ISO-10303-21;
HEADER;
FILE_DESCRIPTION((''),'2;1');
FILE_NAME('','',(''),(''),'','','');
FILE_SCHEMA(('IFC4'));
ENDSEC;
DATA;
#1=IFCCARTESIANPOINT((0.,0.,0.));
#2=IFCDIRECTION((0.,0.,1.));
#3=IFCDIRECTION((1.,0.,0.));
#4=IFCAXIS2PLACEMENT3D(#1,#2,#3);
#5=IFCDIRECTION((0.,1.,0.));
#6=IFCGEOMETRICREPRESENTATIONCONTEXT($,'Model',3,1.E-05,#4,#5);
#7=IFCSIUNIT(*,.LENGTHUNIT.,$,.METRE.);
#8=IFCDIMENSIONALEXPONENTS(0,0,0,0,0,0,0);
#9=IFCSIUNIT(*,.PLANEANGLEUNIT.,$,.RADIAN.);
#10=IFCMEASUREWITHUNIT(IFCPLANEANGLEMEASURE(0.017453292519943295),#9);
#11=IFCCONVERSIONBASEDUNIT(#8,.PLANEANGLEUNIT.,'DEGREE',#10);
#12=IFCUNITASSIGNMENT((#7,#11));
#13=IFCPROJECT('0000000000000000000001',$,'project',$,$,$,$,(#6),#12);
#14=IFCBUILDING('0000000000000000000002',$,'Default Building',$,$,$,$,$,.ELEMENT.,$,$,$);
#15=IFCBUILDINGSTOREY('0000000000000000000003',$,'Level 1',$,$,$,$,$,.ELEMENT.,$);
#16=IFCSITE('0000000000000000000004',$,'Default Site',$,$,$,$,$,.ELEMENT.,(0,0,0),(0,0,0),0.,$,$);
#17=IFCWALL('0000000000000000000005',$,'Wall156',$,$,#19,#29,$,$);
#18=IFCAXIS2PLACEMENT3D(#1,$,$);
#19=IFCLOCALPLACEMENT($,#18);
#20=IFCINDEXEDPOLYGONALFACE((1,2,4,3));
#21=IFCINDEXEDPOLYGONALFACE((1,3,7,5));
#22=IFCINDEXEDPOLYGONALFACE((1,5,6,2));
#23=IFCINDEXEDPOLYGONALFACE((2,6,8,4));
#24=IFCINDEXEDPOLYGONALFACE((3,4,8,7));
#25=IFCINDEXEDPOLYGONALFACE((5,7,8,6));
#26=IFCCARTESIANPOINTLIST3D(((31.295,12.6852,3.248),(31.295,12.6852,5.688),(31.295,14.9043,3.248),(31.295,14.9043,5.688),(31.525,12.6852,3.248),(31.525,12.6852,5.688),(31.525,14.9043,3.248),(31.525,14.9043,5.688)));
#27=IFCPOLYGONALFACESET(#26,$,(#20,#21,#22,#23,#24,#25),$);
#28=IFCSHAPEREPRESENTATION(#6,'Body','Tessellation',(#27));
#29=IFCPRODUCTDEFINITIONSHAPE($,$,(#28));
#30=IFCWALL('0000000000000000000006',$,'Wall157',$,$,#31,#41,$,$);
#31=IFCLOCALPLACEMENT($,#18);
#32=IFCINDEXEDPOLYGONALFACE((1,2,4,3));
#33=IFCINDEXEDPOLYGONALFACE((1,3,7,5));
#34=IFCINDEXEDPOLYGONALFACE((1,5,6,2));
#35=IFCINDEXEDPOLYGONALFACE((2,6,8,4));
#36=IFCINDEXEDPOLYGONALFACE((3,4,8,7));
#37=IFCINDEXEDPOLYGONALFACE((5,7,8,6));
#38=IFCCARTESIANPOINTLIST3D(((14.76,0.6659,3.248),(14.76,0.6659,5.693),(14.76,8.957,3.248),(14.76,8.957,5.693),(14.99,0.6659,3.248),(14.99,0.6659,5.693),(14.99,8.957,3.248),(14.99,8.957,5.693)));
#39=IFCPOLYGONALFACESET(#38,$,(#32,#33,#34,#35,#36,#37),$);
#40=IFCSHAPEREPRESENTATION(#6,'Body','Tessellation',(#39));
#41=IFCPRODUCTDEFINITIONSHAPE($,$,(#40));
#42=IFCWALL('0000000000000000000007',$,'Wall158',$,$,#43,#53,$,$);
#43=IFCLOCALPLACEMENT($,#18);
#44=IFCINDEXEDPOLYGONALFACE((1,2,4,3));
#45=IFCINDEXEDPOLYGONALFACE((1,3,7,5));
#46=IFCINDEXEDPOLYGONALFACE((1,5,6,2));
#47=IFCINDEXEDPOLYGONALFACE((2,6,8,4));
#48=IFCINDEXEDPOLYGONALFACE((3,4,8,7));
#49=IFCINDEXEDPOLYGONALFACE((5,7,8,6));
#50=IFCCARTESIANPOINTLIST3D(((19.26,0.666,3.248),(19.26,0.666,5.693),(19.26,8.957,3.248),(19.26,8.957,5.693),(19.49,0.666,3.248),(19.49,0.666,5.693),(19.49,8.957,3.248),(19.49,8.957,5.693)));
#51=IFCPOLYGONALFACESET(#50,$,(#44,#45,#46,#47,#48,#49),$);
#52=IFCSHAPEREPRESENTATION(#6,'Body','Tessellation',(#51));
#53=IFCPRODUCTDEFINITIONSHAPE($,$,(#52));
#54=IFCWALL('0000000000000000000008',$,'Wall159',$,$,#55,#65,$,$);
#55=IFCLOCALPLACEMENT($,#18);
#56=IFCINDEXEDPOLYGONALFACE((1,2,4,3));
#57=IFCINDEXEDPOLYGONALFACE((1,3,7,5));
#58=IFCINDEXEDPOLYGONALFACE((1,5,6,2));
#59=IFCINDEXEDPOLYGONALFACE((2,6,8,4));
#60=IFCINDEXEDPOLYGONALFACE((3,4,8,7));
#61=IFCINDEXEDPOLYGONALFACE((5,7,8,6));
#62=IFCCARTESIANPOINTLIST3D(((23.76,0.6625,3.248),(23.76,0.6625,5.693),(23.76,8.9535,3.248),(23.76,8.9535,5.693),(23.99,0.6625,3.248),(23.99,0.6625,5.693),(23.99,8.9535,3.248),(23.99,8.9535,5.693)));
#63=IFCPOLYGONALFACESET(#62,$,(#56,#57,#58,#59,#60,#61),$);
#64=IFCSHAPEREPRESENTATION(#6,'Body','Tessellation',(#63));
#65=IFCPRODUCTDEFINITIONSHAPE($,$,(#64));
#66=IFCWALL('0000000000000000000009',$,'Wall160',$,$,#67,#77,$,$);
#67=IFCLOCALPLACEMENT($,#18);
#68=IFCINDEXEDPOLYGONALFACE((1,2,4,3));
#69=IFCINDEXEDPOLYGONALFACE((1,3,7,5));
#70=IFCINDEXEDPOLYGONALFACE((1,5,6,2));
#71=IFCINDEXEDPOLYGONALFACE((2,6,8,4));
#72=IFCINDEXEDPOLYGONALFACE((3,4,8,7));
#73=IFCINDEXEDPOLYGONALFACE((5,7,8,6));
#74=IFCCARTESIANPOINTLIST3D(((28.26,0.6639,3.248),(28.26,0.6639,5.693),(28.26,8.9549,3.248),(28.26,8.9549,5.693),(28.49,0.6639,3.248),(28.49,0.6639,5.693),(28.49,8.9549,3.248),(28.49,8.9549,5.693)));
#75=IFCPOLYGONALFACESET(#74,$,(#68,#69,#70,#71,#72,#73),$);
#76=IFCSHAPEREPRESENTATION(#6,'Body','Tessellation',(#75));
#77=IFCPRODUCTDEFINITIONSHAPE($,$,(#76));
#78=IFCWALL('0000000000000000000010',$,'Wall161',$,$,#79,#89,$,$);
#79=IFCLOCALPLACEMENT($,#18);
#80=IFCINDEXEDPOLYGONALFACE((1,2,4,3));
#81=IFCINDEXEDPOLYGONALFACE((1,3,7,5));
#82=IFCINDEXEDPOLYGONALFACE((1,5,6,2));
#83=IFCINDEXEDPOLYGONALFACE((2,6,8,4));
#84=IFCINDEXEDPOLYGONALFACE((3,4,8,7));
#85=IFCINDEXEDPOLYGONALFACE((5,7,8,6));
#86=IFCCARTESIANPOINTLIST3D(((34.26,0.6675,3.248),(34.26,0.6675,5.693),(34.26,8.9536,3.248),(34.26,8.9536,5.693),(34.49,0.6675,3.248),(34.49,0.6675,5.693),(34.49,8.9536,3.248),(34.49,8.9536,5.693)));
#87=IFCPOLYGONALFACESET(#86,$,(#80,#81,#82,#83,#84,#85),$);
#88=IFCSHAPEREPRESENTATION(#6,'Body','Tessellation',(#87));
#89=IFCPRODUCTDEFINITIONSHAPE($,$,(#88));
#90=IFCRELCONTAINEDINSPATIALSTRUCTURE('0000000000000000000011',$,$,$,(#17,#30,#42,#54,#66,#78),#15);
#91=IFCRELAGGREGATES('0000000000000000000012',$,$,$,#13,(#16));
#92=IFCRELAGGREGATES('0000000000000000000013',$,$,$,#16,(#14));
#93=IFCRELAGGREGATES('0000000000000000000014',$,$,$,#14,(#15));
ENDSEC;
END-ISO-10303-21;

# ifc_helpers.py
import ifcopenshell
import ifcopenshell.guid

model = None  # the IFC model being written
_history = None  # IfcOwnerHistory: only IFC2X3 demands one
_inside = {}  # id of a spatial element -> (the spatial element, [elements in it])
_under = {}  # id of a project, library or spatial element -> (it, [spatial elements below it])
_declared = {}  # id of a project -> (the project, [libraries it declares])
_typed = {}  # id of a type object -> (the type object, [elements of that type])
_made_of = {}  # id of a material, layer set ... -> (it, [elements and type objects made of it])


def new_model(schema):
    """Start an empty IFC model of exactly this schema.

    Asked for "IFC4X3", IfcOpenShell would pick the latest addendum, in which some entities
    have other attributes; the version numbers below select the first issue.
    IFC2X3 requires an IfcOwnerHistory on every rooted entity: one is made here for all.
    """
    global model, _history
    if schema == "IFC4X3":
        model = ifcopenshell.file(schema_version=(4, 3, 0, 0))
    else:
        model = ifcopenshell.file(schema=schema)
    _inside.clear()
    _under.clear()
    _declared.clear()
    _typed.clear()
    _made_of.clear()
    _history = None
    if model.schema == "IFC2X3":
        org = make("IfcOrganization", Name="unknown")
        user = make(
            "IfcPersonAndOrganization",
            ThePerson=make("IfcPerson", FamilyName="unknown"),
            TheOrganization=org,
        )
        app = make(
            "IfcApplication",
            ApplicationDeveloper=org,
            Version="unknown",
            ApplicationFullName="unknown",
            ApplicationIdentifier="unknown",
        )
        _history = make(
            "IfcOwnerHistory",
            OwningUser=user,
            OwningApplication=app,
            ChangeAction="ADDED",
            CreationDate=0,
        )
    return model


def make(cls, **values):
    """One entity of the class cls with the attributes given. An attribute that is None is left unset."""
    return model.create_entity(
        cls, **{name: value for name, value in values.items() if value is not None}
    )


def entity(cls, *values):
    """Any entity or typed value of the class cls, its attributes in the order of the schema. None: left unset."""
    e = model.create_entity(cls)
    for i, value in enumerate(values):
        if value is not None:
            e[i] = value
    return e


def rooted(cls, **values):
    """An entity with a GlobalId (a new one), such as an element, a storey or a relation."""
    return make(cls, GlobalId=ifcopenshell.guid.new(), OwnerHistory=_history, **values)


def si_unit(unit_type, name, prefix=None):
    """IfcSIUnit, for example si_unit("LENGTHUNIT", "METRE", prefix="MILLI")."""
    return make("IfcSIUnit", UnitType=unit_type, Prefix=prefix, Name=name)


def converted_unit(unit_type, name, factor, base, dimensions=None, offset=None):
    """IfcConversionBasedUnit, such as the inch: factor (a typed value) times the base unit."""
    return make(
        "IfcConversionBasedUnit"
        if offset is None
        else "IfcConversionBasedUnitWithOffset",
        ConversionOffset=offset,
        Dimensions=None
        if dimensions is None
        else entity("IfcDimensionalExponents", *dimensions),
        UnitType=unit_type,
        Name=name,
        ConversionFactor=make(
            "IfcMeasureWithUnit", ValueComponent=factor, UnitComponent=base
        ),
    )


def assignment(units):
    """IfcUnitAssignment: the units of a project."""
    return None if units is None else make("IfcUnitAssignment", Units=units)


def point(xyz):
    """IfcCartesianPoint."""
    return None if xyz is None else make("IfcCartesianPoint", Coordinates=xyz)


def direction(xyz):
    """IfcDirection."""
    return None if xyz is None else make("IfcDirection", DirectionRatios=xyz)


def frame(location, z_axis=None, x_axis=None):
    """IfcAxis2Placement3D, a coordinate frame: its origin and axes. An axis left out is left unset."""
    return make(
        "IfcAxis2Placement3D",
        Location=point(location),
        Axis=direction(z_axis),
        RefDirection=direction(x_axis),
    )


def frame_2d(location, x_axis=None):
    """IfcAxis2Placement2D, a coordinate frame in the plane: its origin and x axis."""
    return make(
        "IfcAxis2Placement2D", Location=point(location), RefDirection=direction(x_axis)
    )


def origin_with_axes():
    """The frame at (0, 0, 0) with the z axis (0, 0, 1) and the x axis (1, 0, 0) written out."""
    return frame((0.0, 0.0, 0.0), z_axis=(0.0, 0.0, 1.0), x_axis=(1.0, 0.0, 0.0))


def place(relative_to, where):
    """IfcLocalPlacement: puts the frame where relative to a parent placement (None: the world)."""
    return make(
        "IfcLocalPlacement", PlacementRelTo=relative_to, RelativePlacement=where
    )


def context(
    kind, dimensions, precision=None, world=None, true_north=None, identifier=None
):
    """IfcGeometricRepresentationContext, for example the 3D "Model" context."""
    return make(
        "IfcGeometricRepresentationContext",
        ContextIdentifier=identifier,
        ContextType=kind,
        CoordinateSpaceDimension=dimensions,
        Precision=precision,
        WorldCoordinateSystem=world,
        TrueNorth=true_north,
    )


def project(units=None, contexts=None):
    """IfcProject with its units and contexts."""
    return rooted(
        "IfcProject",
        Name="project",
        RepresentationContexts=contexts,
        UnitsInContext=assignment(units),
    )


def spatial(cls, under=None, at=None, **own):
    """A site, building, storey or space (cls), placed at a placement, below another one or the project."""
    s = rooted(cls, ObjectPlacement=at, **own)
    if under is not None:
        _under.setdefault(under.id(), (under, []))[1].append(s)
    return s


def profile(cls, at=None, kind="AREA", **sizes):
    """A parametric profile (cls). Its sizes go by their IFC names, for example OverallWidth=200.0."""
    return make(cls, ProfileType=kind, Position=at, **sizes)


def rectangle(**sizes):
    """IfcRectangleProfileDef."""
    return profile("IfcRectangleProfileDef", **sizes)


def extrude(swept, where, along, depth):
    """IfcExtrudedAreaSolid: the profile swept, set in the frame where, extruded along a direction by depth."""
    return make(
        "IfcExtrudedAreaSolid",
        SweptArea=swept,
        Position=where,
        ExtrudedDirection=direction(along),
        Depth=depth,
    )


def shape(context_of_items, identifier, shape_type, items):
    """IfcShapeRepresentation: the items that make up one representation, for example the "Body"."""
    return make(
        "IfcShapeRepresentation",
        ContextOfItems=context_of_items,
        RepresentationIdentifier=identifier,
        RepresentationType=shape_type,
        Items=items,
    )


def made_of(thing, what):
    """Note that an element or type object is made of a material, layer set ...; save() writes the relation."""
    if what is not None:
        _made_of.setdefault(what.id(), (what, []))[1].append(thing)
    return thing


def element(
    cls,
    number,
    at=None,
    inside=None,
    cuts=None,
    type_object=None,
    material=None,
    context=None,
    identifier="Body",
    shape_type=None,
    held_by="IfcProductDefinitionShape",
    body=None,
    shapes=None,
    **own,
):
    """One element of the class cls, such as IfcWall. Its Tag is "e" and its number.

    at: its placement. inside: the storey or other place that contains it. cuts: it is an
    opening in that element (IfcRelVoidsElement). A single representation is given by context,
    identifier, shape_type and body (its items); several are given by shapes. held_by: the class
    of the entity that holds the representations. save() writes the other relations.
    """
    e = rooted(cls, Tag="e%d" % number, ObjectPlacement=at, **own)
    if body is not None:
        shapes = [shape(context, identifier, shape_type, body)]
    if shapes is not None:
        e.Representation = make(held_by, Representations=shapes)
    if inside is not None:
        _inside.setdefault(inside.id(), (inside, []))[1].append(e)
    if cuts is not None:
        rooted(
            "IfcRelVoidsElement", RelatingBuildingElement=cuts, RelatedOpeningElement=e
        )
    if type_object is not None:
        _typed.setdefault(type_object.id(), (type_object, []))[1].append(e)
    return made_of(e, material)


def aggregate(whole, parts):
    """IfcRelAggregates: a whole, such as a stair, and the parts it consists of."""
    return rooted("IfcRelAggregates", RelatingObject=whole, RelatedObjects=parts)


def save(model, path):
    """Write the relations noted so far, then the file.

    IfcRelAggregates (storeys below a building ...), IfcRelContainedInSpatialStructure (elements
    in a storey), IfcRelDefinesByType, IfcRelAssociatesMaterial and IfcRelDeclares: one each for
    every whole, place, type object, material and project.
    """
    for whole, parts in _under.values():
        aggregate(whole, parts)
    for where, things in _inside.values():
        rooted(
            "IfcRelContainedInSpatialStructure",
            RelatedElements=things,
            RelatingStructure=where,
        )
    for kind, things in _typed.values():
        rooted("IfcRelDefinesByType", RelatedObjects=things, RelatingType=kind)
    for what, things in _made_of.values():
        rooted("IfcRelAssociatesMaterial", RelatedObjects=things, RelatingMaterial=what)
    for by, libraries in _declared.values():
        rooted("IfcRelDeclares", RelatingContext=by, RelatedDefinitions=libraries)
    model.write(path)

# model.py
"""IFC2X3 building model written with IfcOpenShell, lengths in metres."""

from ifc_helpers import new_model, entity, si_unit, converted_unit, direction, frame, frame_2d, origin_with_axes, place, context, project, spatial, rectangle, extrude, element, save


model = new_model("IFC2X3")

# Units and contexts
model_context = context("Model", 3, precision=1e-05, world=origin_with_axes(), true_north=direction((0.0, 1.0, 0.0)))
ifc_project = project(units=[si_unit("LENGTHUNIT", "METRE"), converted_unit("PLANEANGLEUNIT", "DEGREE", entity("IfcPlaneAngleMeasure", 0.017453292519943295), si_unit("PLANEANGLEUNIT", "RADIAN"), dimensions=[0, 0, 0, 0, 0, 0, 0])], contexts=[model_context])

# Site, building, storey
site = spatial("IfcSite", under=ifc_project, Name="Default Site", CompositionType="ELEMENT", RefLatitude=(0, 0, 0), RefLongitude=(0, 0, 0), RefElevation=0.0)
building = spatial("IfcBuilding", under=site, Name="Default Building", CompositionType="ELEMENT")
storey = spatial("IfcBuildingStorey", under=building, Name="Level 1", CompositionType="ELEMENT")

# Shared definitions
placement = place(None, origin_with_axes())

# Walls
element("IfcWall", 1, at=placement, inside=storey, Name="Wall156", context=model_context, shape_type="SweptSolid", body=[
    extrude(rectangle(XDim=2.2191, YDim=0.23, at=frame_2d((0.0, 0.0), x_axis=(0.0, 1.0, 0.0))), frame((31.41, 13.7948, 3.248), z_axis=(0.0, 0.0, 1.0), x_axis=(1.0, 0.0, 0.0)), (0.0, 0.0, 1.0), 2.44),
])
element("IfcWall", 2, at=placement, inside=storey, Name="Wall157", context=model_context, shape_type="SweptSolid", body=[
    extrude(rectangle(XDim=8.291, YDim=0.23, at=frame_2d((0.0, 0.0), x_axis=(0.0, 1.0, 0.0))), frame((14.875, 4.8114, 3.248), z_axis=(0.0, 0.0, 1.0), x_axis=(1.0, 0.0, 0.0)), (0.0, 0.0, 1.0), 2.445),
])
element("IfcWall", 3, at=placement, inside=storey, Name="Wall158", context=model_context, shape_type="SweptSolid", body=[
    extrude(rectangle(XDim=8.291, YDim=0.23, at=frame_2d((0.0, 0.0), x_axis=(0.0, 1.0, 0.0))), frame((19.375, 4.8115, 3.248), z_axis=(0.0, 0.0, 1.0), x_axis=(1.0, 0.0, 0.0)), (0.0, 0.0, 1.0), 2.445),
])
element("IfcWall", 4, at=placement, inside=storey, Name="Wall159", context=model_context, shape_type="SweptSolid", body=[
    extrude(rectangle(XDim=8.291, YDim=0.23, at=frame_2d((0.0, 0.0), x_axis=(0.0, 1.0, 0.0))), frame((23.875, 4.808, 3.248), z_axis=(0.0, 0.0, 1.0), x_axis=(1.0, 0.0, 0.0)), (0.0, 0.0, 1.0), 2.445),
])
element("IfcWall", 5, at=placement, inside=storey, Name="Wall160", context=model_context, shape_type="SweptSolid", body=[
    extrude(rectangle(XDim=8.291, YDim=0.23, at=frame_2d((0.0, 0.0), x_axis=(0.0, 1.0, 0.0))), frame((28.375, 4.8094, 3.248), z_axis=(0.0, 0.0, 1.0), x_axis=(1.0, 0.0, 0.0)), (0.0, 0.0, 1.0), 2.445),
])
element("IfcWall", 6, at=placement, inside=storey, Name="Wall161", context=model_context, shape_type="SweptSolid", body=[
    extrude(rectangle(XDim=8.2861, YDim=0.23, at=frame_2d((0.0, 0.0), x_axis=(0.0, 1.0, 0.0))), frame((34.375, 4.8106, 3.248), z_axis=(0.0, 0.0, 1.0), x_axis=(1.0, 0.0, 0.0)), (0.0, 0.0, 1.0), 2.445),
])

save(model, "model.ifc")
